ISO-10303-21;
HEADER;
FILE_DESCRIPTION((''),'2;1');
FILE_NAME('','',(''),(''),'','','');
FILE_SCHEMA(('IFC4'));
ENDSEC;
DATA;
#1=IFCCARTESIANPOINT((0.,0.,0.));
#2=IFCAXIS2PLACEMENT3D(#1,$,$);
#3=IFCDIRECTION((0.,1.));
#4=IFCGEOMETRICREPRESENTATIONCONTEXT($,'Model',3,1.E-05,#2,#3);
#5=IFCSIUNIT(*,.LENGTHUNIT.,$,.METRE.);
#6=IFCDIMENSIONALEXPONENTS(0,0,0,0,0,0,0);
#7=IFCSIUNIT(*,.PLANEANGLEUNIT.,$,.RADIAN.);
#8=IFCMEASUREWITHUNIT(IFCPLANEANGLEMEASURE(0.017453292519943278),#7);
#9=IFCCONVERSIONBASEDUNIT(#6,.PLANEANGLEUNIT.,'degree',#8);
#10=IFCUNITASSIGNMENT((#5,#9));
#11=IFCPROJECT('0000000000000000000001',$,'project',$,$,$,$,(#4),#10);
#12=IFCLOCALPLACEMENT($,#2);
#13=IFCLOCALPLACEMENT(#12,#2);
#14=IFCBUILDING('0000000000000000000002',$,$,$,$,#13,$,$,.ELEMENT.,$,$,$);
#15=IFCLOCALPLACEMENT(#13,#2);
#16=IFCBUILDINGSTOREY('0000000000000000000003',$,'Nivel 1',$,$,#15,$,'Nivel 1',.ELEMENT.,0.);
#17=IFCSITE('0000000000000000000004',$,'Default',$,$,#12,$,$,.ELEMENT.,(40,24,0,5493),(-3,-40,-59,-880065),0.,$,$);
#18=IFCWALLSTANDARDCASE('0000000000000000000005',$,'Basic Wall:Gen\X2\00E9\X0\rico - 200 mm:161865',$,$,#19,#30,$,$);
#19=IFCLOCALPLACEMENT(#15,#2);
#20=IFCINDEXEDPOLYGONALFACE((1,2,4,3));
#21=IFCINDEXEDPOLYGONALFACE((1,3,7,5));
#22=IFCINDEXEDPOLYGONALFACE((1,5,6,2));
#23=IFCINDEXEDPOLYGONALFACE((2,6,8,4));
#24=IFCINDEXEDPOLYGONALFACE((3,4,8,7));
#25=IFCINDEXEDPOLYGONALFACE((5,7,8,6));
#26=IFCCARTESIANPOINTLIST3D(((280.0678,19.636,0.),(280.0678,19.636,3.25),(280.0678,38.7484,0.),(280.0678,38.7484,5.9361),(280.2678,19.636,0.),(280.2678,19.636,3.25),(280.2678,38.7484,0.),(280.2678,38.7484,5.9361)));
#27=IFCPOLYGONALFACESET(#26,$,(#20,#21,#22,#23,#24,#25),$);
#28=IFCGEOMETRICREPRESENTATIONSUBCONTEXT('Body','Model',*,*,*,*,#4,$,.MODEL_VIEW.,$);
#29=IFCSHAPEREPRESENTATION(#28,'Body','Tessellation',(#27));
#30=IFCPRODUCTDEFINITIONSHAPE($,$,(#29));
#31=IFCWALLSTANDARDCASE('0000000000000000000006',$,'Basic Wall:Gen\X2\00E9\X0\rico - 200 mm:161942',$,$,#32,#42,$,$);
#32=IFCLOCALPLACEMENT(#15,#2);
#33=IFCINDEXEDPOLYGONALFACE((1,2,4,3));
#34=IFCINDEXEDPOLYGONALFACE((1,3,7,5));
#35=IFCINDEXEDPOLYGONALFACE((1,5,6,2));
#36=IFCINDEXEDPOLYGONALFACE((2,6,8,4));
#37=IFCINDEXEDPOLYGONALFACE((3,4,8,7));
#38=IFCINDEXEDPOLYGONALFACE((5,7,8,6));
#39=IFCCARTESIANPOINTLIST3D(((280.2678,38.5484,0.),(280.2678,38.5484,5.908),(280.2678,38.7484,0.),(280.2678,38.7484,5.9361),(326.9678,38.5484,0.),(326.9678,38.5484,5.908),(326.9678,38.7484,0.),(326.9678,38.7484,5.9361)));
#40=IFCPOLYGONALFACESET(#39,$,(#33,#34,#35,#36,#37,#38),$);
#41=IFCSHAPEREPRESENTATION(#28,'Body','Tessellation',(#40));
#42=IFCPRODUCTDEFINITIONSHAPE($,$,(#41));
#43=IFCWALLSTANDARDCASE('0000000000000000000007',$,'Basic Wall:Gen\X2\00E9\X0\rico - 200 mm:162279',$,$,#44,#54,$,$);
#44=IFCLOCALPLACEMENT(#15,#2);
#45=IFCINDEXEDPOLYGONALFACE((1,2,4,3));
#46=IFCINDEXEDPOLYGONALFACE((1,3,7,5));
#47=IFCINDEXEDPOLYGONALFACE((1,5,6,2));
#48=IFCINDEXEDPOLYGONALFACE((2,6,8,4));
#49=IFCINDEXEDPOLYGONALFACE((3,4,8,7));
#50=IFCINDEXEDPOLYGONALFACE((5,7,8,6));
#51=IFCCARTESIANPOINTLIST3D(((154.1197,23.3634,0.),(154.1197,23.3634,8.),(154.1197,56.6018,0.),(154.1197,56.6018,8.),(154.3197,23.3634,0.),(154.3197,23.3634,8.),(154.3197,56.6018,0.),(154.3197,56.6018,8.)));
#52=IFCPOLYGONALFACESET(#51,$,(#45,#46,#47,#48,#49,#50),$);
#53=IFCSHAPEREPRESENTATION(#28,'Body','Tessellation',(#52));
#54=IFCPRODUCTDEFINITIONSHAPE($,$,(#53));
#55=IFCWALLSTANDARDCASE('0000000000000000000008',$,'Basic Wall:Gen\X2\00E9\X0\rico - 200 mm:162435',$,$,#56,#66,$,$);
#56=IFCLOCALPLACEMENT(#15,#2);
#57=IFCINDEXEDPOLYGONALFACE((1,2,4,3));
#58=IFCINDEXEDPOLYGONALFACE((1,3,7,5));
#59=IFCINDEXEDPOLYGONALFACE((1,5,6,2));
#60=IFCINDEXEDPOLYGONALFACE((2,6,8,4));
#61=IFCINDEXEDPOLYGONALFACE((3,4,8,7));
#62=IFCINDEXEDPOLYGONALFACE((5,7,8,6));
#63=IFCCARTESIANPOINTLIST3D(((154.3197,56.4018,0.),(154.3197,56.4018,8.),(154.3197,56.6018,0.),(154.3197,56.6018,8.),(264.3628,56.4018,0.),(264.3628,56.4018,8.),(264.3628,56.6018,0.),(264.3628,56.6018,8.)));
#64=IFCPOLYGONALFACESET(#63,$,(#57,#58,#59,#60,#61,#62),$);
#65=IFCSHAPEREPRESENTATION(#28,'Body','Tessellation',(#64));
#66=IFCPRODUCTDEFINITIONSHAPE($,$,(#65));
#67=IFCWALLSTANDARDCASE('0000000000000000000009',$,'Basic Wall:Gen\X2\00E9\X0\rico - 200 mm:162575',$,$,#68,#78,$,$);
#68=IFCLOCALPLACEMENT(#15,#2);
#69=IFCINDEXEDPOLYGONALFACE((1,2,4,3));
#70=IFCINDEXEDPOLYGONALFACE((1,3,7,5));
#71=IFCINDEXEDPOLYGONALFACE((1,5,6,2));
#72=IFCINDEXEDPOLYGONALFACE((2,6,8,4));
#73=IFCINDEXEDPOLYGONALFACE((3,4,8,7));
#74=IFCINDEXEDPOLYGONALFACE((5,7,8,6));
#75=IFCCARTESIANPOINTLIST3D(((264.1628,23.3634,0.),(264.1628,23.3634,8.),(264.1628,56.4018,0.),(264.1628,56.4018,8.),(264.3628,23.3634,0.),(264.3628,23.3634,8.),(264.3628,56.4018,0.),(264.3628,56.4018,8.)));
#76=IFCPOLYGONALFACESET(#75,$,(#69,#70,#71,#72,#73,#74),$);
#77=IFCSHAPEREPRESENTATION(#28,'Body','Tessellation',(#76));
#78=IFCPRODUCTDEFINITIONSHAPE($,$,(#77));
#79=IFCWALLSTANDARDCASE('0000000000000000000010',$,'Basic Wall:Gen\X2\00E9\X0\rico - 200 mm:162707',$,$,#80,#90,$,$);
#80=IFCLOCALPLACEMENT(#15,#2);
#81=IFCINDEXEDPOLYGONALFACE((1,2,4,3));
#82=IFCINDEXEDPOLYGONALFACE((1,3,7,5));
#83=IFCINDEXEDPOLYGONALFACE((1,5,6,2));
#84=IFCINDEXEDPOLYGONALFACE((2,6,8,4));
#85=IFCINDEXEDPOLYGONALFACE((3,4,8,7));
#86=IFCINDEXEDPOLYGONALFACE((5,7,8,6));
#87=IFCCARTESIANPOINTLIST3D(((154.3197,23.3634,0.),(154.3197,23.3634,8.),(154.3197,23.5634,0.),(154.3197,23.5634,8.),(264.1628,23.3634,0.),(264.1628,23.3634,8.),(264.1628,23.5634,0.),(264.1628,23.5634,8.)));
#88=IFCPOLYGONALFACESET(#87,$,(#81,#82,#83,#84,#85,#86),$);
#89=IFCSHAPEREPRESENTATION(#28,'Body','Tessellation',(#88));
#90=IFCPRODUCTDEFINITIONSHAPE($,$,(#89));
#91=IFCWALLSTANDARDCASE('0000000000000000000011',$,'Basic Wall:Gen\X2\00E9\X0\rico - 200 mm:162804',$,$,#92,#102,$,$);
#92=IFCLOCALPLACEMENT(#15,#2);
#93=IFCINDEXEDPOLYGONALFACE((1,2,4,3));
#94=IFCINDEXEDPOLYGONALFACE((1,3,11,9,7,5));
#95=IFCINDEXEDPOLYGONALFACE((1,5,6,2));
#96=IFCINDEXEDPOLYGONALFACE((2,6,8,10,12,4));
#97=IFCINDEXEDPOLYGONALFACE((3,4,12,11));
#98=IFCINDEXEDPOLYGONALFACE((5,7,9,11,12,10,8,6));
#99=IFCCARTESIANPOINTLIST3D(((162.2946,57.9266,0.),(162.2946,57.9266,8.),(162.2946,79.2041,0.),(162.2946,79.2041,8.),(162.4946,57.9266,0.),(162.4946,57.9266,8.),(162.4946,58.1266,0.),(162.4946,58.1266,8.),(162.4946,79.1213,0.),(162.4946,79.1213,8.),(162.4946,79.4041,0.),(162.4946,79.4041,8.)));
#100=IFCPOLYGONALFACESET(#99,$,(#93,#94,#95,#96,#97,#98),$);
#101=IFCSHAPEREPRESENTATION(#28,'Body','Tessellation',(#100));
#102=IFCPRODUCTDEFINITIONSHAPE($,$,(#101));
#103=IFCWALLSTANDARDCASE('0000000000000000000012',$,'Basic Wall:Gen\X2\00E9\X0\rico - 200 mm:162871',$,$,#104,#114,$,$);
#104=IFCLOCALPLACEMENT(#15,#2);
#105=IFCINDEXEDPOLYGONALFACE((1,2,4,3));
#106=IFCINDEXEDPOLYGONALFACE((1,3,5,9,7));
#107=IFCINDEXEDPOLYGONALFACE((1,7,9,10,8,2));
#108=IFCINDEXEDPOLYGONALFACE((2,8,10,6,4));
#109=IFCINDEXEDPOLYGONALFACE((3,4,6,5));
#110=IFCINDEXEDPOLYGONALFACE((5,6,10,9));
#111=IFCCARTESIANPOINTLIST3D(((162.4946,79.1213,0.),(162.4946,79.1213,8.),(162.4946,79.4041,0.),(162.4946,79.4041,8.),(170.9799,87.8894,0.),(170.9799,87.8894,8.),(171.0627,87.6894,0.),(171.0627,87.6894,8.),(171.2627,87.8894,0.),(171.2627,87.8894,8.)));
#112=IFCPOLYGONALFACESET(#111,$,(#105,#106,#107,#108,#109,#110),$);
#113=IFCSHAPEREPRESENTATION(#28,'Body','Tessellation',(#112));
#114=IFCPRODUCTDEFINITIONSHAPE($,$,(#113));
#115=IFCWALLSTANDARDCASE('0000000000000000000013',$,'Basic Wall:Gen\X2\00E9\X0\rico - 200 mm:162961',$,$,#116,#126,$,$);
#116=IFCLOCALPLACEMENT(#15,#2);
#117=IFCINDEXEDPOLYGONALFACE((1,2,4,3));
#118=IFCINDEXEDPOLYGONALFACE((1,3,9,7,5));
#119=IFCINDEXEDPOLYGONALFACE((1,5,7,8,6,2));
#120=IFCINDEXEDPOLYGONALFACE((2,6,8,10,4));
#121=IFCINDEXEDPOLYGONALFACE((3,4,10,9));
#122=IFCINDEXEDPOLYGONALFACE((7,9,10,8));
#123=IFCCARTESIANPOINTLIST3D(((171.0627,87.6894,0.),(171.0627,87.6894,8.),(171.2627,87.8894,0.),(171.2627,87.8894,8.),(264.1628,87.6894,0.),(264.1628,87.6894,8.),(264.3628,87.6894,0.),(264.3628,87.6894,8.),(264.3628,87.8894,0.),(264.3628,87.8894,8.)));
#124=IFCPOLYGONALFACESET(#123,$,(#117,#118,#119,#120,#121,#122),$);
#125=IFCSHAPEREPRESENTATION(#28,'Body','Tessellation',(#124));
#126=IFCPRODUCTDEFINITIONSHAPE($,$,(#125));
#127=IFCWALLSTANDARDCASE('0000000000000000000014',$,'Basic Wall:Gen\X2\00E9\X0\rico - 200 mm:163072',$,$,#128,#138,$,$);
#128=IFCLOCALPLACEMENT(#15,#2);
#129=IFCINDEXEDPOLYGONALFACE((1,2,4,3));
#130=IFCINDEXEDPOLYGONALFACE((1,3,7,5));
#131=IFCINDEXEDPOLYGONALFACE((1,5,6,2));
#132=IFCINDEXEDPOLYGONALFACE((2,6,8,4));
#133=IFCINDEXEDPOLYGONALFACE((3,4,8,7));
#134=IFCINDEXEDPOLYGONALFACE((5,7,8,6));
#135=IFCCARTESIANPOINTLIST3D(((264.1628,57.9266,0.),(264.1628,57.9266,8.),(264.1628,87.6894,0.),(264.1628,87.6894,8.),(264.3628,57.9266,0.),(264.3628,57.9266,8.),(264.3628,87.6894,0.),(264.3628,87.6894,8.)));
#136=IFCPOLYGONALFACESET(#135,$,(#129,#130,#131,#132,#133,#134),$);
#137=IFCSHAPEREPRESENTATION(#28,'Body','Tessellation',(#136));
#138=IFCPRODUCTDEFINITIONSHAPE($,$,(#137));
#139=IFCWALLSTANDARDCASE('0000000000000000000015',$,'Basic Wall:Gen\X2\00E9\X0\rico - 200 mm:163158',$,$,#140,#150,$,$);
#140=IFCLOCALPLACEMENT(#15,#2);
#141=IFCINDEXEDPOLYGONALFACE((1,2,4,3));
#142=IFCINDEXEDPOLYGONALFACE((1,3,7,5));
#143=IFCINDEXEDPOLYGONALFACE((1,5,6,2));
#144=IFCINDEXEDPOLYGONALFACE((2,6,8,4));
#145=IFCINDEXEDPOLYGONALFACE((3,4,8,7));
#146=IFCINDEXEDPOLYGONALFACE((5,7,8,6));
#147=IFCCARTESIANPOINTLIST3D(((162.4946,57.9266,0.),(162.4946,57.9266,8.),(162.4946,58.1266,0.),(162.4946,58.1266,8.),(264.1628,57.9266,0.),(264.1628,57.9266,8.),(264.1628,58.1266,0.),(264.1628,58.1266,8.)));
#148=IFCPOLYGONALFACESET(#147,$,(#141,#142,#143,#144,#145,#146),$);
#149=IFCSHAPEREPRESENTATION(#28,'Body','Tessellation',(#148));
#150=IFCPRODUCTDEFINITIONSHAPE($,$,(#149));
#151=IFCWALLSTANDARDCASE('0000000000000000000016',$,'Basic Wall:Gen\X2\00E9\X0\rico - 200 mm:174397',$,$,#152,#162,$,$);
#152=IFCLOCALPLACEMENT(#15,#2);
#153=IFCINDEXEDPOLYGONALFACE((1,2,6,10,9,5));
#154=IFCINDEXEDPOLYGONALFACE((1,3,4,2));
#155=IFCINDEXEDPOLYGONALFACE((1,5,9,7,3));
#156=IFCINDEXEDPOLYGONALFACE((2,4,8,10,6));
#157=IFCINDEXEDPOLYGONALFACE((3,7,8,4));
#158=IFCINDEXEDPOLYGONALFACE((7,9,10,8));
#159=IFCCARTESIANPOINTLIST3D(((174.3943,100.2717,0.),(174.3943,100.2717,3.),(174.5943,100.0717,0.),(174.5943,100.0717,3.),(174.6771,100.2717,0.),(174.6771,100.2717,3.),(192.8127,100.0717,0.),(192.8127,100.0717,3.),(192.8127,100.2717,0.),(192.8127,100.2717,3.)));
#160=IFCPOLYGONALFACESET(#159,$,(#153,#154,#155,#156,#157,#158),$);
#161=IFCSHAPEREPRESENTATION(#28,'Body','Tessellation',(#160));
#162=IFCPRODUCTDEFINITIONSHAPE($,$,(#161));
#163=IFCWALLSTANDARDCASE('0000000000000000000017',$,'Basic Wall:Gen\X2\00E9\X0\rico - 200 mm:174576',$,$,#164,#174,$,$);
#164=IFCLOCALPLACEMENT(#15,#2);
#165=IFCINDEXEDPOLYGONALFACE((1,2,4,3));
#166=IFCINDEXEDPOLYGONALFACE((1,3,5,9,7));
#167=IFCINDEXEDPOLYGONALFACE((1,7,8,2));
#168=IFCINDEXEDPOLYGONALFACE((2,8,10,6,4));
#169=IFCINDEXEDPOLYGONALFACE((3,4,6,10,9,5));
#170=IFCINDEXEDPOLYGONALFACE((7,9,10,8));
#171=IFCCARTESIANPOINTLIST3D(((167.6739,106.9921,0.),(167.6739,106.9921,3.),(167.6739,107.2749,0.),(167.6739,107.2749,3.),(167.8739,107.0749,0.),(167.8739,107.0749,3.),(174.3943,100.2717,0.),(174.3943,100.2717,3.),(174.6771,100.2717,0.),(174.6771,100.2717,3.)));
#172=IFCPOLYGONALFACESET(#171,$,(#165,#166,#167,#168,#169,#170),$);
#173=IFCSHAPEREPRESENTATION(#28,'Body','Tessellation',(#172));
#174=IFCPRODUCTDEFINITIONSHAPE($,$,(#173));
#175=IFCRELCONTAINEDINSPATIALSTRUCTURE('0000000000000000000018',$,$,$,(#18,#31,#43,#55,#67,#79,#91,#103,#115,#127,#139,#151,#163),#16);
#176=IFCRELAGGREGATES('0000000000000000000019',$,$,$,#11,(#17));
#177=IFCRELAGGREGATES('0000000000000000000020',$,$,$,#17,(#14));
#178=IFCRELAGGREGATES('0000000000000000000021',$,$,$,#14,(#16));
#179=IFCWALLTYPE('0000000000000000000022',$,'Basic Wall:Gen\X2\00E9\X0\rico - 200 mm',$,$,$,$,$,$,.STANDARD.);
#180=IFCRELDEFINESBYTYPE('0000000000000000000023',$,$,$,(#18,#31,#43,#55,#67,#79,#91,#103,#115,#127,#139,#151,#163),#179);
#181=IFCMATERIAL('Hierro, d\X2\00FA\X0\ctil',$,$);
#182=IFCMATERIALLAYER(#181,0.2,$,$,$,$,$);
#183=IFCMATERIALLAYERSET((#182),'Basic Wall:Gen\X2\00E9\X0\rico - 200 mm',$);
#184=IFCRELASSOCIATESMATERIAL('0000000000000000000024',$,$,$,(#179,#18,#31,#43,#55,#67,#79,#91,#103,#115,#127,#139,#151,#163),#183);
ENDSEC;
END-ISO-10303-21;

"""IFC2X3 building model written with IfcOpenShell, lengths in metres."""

from ifc_helpers import new_model, entity, si_unit, converted_unit, direction, frame, frame_2d, origin, place, context, subcontext, project, spatial, polyline, rectangle, outline, extrude, clip, bounded_halfspace, material, layer, layer_set, layer_usage, type_object, element, save


model = new_model("IFC2X3")

# Units and contexts
model_context = context("Model", 3, precision=1e-05, world=origin(), true_north=direction((0.0, 1.0)))
body_context = subcontext(model_context, "Body", "Model", "MODEL_VIEW")
ifc_project = project(units=[si_unit("LENGTHUNIT", "METRE"), converted_unit("PLANEANGLEUNIT", "degree", entity("IfcPlaneAngleMeasure", 0.017453292519943278), si_unit("PLANEANGLEUNIT", "RADIAN"), dimensions=[0, 0, 0, 0, 0, 0, 0])], contexts=[model_context])

# Site, building, storey
site_placement = place(None, origin())
site = spatial("IfcSite", under=ifc_project, at=site_placement, Name="Default", CompositionType="ELEMENT", RefLatitude=(40, 24, 0, 5493), RefLongitude=(-3, -40, -59, -880065), RefElevation=0.0)
building_placement = place(site_placement, origin())
building = spatial("IfcBuilding", under=site, at=building_placement, CompositionType="ELEMENT")
storey_placement = place(building_placement, origin())
storey = spatial("IfcBuildingStorey", under=building, at=storey_placement, Name="Nivel 1", LongName="Nivel 1", CompositionType="ELEMENT", Elevation=0.0)

# Walls
ifc_material_1 = material(Name="Hierro, dúctil")
ifc_layer_1 = layer(ifc_material_1, 0.2)
ifc_layer_set_1 = layer_set([ifc_layer_1], Name="Basic Wall:Genérico - 200 mm")
ifc_layer_usage_1 = layer_usage(ifc_layer_set_1, "AXIS2", "NEGATIVE", 0.1)
wall_type = type_object("IfcWallType", Name="Basic Wall:Genérico - 200 mm", PredefinedType="STANDARD", material=ifc_layer_set_1)
wall_1_placement = place(storey_placement, frame((280.1678, 19.636, 0.0), z_axis=(0.0, 0.0, 1.0), x_axis=(0.0, 1.0, 0.0)))
element("IfcWallStandardCase", 1, at=wall_1_placement, inside=storey, type_object=wall_type, material=ifc_layer_usage_1, Name="Basic Wall:Genérico - 200 mm:161865", context=body_context, shape_type="Clipping", body=[
    clip(extrude(rectangle(XDim=19.1123, YDim=0.2, at=frame_2d((9.5562, 0.0), x_axis=(-1.0, 0.0))), origin(), (0.0, 0.0, 1.0), 5.9361), bounded_halfspace(frame((0.0, -0.1, 3.25), z_axis=(-0.139173, 0.0, 0.990268), x_axis=(0.0, -1.0, 0.0)), False, frame((0.0, -0.1, 3.25)), polyline([(0.0, 0.0), (0.2, 0.0), (18.9123, 0.0), (19.1123, 0.0), (19.1123, 0.2), (0.0, 0.2), (0.0, 0.0)]))),
])
ifc_layer_usage_2 = layer_usage(ifc_layer_set_1, "AXIS2", "NEGATIVE", 0.1)
wall_2_placement = place(storey_placement, frame((280.2678, 38.6484, 0.0)))
element("IfcWallStandardCase", 2, at=wall_2_placement, inside=storey, type_object=wall_type, material=ifc_layer_usage_2, Name="Basic Wall:Genérico - 200 mm:161942", context=body_context, shape_type="Clipping", body=[
    clip(extrude(rectangle(XDim=46.7, YDim=0.2, at=frame_2d((23.35, 0.0), x_axis=(-1.0, 0.0))), origin(), (0.0, 0.0, 1.0), 5.9361), bounded_halfspace(frame((0.0, -0.1, 5.908), z_axis=(0.0, -0.139173, 0.990268), x_axis=(1.0, 0.0, 0.0)), False, frame((0.0, -0.1, 5.908)), polyline([(0.0, 0.0), (46.5, 0.0), (46.7, 0.0), (46.7, 0.2), (0.0, 0.2), (0.0, 0.0)]))),
])
ifc_layer_usage_3 = layer_usage(ifc_layer_set_1, "AXIS2", "NEGATIVE", 0.1)
wall_3_placement = place(storey_placement, frame((154.2197, 23.3634, 0.0), z_axis=(0.0, 0.0, 1.0), x_axis=(0.0, 1.0, 0.0)))
element("IfcWallStandardCase", 3, at=wall_3_placement, inside=storey, type_object=wall_type, material=ifc_layer_usage_3, Name="Basic Wall:Genérico - 200 mm:162279", context=body_context, shape_type="SweptSolid", body=[
    extrude(rectangle(XDim=33.2383, YDim=0.2, at=frame_2d((16.6192, 0.0), x_axis=(-1.0, 0.0))), origin(), (0.0, 0.0, 1.0), 8.0),
])
ifc_layer_usage_4 = layer_usage(ifc_layer_set_1, "AXIS2", "NEGATIVE", 0.1)
wall_4_placement = place(storey_placement, frame((154.3197, 56.5018, 0.0)))
element("IfcWallStandardCase", 4, at=wall_4_placement, inside=storey, type_object=wall_type, material=ifc_layer_usage_4, Name="Basic Wall:Genérico - 200 mm:162435", context=body_context, shape_type="SweptSolid", body=[
    extrude(rectangle(XDim=110.0431, YDim=0.2, at=frame_2d((55.0215, 0.0), x_axis=(-1.0, 0.0))), origin(), (0.0, 0.0, 1.0), 8.0),
])
ifc_layer_usage_5 = layer_usage(ifc_layer_set_1, "AXIS2", "NEGATIVE", 0.1)
wall_5_placement = place(storey_placement, frame((264.2628, 56.4018, 0.0), z_axis=(0.0, 0.0, 1.0), x_axis=(0.0, -1.0, 0.0)))
element("IfcWallStandardCase", 5, at=wall_5_placement, inside=storey, type_object=wall_type, material=ifc_layer_usage_5, Name="Basic Wall:Genérico - 200 mm:162575", context=body_context, shape_type="SweptSolid", body=[
    extrude(rectangle(XDim=33.0383, YDim=0.2, at=frame_2d((16.5192, 0.0), x_axis=(-1.0, 0.0))), origin(), (0.0, 0.0, 1.0), 8.0),
])
ifc_layer_usage_6 = layer_usage(ifc_layer_set_1, "AXIS2", "NEGATIVE", 0.1)
wall_6_placement = place(storey_placement, frame((264.1628, 23.4634, 0.0), z_axis=(0.0, 0.0, 1.0), x_axis=(-1.0, 0.0, 0.0)))
element("IfcWallStandardCase", 6, at=wall_6_placement, inside=storey, type_object=wall_type, material=ifc_layer_usage_6, Name="Basic Wall:Genérico - 200 mm:162707", context=body_context, shape_type="SweptSolid", body=[
    extrude(rectangle(XDim=109.8431, YDim=0.2, at=frame_2d((54.9215, 0.0), x_axis=(-1.0, 0.0))), origin(), (0.0, 0.0, 1.0), 8.0),
])
ifc_layer_usage_7 = layer_usage(ifc_layer_set_1, "AXIS2", "NEGATIVE", 0.1)
wall_7_placement = place(storey_placement, frame((162.3946, 57.9266, 0.0), z_axis=(0.0, 0.0, 1.0), x_axis=(0.0, 1.0, 0.0)))
element("IfcWallStandardCase", 7, at=wall_7_placement, inside=storey, type_object=wall_type, material=ifc_layer_usage_7, Name="Basic Wall:Genérico - 200 mm:162804", context=body_context, shape_type="SweptSolid", body=[
    extrude(outline(polyline([(21.4775, -0.1), (21.2775, 0.1), (0.0, 0.1), (0.0, -0.1), (0.2, -0.1), (21.1946, -0.1), (21.4775, -0.1)])), origin(), (0.0, 0.0, 1.0), 8.0),
])
ifc_layer_usage_8 = layer_usage(ifc_layer_set_1, "AXIS2", "NEGATIVE", 0.1)
wall_8_placement = place(storey_placement, frame((162.4239, 79.192, 0.0), z_axis=(0.0, 0.0, 1.0), x_axis=(0.707107, 0.707107, 0.0)))
element("IfcWallStandardCase", 8, at=wall_8_placement, inside=storey, type_object=wall_type, material=ifc_layer_usage_8, Name="Basic Wall:Genérico - 200 mm:162871", context=body_context, shape_type="SweptSolid", body=[
    extrude(outline(polyline([(12.4, -0.1), (12.2, 0.1), (0.2, 0.1), (0.0, -0.1), (12.1172, -0.1), (12.4, -0.1)])), origin(), (0.0, 0.0, 1.0), 8.0),
])
ifc_layer_usage_9 = layer_usage(ifc_layer_set_1, "AXIS2", "NEGATIVE", 0.1)
wall_9_placement = place(storey_placement, frame((171.0627, 87.7894, 0.0)))
element("IfcWallStandardCase", 9, at=wall_9_placement, inside=storey, type_object=wall_type, material=ifc_layer_usage_9, Name="Basic Wall:Genérico - 200 mm:162961", context=body_context, shape_type="SweptSolid", body=[
    extrude(outline(polyline([(93.3001, -0.1), (93.3001, 0.1), (0.2, 0.1), (0.0, -0.1), (93.1001, -0.1), (93.3001, -0.1)])), origin(), (0.0, 0.0, 1.0), 8.0),
])
ifc_layer_usage_10 = layer_usage(ifc_layer_set_1, "AXIS2", "NEGATIVE", 0.1)
wall_10_placement = place(storey_placement, frame((264.2628, 87.6894, 0.0), z_axis=(0.0, 0.0, 1.0), x_axis=(0.0, -1.0, 0.0)))
element("IfcWallStandardCase", 10, at=wall_10_placement, inside=storey, type_object=wall_type, material=ifc_layer_usage_10, Name="Basic Wall:Genérico - 200 mm:163072", context=body_context, shape_type="SweptSolid", body=[
    extrude(rectangle(XDim=29.7628, YDim=0.2, at=frame_2d((14.8814, 0.0), x_axis=(-1.0, 0.0))), origin(), (0.0, 0.0, 1.0), 8.0),
])
ifc_layer_usage_11 = layer_usage(ifc_layer_set_1, "AXIS2", "NEGATIVE", 0.1)
wall_11_placement = place(storey_placement, frame((264.1628, 58.0266, 0.0), z_axis=(0.0, 0.0, 1.0), x_axis=(-1.0, 0.0, 0.0)))
element("IfcWallStandardCase", 11, at=wall_11_placement, inside=storey, type_object=wall_type, material=ifc_layer_usage_11, Name="Basic Wall:Genérico - 200 mm:163158", context=body_context, shape_type="SweptSolid", body=[
    extrude(rectangle(XDim=101.6682, YDim=0.2, at=frame_2d((50.8341, 0.0), x_axis=(-1.0, 0.0))), origin(), (0.0, 0.0, 1.0), 8.0),
])
ifc_layer_usage_12 = layer_usage(ifc_layer_set_1, "AXIS2", "NEGATIVE", 0.1)
wall_12_placement = place(storey_placement, frame((192.8127, 100.1717, 0.0), z_axis=(0.0, 0.0, 1.0), x_axis=(-1.0, 0.0, 0.0)))
element("IfcWallStandardCase", 12, at=wall_12_placement, inside=storey, type_object=wall_type, material=ifc_layer_usage_12, Name="Basic Wall:Genérico - 200 mm:174397", context=body_context, shape_type="SweptSolid", body=[
    extrude(outline(polyline([(18.4184, -0.1), (18.2184, 0.1), (0.0, 0.1), (0.0, -0.1), (18.1356, -0.1), (18.4184, -0.1)])), origin(), (0.0, 0.0, 1.0), 3.0),
])
ifc_layer_usage_13 = layer_usage(ifc_layer_set_1, "AXIS2", "NEGATIVE", 0.1)
wall_13_placement = place(storey_placement, frame((174.6064, 100.201, 0.0), z_axis=(0.0, 0.0, 1.0), x_axis=(-0.707107, 0.707107, 0.0)))
element("IfcWallStandardCase", 13, at=wall_13_placement, inside=storey, type_object=wall_type, material=ifc_layer_usage_13, Name="Basic Wall:Genérico - 200 mm:174576", context=body_context, shape_type="SweptSolid", body=[
    extrude(outline(polyline([(9.9041, -0.1), (9.7041, 0.1), (0.2, 0.1), (0.0, -0.1), (9.6212, -0.1), (9.9041, -0.1)])), origin(), (0.0, 0.0, 1.0), 3.0),
])

save(model, "model.ifc")
